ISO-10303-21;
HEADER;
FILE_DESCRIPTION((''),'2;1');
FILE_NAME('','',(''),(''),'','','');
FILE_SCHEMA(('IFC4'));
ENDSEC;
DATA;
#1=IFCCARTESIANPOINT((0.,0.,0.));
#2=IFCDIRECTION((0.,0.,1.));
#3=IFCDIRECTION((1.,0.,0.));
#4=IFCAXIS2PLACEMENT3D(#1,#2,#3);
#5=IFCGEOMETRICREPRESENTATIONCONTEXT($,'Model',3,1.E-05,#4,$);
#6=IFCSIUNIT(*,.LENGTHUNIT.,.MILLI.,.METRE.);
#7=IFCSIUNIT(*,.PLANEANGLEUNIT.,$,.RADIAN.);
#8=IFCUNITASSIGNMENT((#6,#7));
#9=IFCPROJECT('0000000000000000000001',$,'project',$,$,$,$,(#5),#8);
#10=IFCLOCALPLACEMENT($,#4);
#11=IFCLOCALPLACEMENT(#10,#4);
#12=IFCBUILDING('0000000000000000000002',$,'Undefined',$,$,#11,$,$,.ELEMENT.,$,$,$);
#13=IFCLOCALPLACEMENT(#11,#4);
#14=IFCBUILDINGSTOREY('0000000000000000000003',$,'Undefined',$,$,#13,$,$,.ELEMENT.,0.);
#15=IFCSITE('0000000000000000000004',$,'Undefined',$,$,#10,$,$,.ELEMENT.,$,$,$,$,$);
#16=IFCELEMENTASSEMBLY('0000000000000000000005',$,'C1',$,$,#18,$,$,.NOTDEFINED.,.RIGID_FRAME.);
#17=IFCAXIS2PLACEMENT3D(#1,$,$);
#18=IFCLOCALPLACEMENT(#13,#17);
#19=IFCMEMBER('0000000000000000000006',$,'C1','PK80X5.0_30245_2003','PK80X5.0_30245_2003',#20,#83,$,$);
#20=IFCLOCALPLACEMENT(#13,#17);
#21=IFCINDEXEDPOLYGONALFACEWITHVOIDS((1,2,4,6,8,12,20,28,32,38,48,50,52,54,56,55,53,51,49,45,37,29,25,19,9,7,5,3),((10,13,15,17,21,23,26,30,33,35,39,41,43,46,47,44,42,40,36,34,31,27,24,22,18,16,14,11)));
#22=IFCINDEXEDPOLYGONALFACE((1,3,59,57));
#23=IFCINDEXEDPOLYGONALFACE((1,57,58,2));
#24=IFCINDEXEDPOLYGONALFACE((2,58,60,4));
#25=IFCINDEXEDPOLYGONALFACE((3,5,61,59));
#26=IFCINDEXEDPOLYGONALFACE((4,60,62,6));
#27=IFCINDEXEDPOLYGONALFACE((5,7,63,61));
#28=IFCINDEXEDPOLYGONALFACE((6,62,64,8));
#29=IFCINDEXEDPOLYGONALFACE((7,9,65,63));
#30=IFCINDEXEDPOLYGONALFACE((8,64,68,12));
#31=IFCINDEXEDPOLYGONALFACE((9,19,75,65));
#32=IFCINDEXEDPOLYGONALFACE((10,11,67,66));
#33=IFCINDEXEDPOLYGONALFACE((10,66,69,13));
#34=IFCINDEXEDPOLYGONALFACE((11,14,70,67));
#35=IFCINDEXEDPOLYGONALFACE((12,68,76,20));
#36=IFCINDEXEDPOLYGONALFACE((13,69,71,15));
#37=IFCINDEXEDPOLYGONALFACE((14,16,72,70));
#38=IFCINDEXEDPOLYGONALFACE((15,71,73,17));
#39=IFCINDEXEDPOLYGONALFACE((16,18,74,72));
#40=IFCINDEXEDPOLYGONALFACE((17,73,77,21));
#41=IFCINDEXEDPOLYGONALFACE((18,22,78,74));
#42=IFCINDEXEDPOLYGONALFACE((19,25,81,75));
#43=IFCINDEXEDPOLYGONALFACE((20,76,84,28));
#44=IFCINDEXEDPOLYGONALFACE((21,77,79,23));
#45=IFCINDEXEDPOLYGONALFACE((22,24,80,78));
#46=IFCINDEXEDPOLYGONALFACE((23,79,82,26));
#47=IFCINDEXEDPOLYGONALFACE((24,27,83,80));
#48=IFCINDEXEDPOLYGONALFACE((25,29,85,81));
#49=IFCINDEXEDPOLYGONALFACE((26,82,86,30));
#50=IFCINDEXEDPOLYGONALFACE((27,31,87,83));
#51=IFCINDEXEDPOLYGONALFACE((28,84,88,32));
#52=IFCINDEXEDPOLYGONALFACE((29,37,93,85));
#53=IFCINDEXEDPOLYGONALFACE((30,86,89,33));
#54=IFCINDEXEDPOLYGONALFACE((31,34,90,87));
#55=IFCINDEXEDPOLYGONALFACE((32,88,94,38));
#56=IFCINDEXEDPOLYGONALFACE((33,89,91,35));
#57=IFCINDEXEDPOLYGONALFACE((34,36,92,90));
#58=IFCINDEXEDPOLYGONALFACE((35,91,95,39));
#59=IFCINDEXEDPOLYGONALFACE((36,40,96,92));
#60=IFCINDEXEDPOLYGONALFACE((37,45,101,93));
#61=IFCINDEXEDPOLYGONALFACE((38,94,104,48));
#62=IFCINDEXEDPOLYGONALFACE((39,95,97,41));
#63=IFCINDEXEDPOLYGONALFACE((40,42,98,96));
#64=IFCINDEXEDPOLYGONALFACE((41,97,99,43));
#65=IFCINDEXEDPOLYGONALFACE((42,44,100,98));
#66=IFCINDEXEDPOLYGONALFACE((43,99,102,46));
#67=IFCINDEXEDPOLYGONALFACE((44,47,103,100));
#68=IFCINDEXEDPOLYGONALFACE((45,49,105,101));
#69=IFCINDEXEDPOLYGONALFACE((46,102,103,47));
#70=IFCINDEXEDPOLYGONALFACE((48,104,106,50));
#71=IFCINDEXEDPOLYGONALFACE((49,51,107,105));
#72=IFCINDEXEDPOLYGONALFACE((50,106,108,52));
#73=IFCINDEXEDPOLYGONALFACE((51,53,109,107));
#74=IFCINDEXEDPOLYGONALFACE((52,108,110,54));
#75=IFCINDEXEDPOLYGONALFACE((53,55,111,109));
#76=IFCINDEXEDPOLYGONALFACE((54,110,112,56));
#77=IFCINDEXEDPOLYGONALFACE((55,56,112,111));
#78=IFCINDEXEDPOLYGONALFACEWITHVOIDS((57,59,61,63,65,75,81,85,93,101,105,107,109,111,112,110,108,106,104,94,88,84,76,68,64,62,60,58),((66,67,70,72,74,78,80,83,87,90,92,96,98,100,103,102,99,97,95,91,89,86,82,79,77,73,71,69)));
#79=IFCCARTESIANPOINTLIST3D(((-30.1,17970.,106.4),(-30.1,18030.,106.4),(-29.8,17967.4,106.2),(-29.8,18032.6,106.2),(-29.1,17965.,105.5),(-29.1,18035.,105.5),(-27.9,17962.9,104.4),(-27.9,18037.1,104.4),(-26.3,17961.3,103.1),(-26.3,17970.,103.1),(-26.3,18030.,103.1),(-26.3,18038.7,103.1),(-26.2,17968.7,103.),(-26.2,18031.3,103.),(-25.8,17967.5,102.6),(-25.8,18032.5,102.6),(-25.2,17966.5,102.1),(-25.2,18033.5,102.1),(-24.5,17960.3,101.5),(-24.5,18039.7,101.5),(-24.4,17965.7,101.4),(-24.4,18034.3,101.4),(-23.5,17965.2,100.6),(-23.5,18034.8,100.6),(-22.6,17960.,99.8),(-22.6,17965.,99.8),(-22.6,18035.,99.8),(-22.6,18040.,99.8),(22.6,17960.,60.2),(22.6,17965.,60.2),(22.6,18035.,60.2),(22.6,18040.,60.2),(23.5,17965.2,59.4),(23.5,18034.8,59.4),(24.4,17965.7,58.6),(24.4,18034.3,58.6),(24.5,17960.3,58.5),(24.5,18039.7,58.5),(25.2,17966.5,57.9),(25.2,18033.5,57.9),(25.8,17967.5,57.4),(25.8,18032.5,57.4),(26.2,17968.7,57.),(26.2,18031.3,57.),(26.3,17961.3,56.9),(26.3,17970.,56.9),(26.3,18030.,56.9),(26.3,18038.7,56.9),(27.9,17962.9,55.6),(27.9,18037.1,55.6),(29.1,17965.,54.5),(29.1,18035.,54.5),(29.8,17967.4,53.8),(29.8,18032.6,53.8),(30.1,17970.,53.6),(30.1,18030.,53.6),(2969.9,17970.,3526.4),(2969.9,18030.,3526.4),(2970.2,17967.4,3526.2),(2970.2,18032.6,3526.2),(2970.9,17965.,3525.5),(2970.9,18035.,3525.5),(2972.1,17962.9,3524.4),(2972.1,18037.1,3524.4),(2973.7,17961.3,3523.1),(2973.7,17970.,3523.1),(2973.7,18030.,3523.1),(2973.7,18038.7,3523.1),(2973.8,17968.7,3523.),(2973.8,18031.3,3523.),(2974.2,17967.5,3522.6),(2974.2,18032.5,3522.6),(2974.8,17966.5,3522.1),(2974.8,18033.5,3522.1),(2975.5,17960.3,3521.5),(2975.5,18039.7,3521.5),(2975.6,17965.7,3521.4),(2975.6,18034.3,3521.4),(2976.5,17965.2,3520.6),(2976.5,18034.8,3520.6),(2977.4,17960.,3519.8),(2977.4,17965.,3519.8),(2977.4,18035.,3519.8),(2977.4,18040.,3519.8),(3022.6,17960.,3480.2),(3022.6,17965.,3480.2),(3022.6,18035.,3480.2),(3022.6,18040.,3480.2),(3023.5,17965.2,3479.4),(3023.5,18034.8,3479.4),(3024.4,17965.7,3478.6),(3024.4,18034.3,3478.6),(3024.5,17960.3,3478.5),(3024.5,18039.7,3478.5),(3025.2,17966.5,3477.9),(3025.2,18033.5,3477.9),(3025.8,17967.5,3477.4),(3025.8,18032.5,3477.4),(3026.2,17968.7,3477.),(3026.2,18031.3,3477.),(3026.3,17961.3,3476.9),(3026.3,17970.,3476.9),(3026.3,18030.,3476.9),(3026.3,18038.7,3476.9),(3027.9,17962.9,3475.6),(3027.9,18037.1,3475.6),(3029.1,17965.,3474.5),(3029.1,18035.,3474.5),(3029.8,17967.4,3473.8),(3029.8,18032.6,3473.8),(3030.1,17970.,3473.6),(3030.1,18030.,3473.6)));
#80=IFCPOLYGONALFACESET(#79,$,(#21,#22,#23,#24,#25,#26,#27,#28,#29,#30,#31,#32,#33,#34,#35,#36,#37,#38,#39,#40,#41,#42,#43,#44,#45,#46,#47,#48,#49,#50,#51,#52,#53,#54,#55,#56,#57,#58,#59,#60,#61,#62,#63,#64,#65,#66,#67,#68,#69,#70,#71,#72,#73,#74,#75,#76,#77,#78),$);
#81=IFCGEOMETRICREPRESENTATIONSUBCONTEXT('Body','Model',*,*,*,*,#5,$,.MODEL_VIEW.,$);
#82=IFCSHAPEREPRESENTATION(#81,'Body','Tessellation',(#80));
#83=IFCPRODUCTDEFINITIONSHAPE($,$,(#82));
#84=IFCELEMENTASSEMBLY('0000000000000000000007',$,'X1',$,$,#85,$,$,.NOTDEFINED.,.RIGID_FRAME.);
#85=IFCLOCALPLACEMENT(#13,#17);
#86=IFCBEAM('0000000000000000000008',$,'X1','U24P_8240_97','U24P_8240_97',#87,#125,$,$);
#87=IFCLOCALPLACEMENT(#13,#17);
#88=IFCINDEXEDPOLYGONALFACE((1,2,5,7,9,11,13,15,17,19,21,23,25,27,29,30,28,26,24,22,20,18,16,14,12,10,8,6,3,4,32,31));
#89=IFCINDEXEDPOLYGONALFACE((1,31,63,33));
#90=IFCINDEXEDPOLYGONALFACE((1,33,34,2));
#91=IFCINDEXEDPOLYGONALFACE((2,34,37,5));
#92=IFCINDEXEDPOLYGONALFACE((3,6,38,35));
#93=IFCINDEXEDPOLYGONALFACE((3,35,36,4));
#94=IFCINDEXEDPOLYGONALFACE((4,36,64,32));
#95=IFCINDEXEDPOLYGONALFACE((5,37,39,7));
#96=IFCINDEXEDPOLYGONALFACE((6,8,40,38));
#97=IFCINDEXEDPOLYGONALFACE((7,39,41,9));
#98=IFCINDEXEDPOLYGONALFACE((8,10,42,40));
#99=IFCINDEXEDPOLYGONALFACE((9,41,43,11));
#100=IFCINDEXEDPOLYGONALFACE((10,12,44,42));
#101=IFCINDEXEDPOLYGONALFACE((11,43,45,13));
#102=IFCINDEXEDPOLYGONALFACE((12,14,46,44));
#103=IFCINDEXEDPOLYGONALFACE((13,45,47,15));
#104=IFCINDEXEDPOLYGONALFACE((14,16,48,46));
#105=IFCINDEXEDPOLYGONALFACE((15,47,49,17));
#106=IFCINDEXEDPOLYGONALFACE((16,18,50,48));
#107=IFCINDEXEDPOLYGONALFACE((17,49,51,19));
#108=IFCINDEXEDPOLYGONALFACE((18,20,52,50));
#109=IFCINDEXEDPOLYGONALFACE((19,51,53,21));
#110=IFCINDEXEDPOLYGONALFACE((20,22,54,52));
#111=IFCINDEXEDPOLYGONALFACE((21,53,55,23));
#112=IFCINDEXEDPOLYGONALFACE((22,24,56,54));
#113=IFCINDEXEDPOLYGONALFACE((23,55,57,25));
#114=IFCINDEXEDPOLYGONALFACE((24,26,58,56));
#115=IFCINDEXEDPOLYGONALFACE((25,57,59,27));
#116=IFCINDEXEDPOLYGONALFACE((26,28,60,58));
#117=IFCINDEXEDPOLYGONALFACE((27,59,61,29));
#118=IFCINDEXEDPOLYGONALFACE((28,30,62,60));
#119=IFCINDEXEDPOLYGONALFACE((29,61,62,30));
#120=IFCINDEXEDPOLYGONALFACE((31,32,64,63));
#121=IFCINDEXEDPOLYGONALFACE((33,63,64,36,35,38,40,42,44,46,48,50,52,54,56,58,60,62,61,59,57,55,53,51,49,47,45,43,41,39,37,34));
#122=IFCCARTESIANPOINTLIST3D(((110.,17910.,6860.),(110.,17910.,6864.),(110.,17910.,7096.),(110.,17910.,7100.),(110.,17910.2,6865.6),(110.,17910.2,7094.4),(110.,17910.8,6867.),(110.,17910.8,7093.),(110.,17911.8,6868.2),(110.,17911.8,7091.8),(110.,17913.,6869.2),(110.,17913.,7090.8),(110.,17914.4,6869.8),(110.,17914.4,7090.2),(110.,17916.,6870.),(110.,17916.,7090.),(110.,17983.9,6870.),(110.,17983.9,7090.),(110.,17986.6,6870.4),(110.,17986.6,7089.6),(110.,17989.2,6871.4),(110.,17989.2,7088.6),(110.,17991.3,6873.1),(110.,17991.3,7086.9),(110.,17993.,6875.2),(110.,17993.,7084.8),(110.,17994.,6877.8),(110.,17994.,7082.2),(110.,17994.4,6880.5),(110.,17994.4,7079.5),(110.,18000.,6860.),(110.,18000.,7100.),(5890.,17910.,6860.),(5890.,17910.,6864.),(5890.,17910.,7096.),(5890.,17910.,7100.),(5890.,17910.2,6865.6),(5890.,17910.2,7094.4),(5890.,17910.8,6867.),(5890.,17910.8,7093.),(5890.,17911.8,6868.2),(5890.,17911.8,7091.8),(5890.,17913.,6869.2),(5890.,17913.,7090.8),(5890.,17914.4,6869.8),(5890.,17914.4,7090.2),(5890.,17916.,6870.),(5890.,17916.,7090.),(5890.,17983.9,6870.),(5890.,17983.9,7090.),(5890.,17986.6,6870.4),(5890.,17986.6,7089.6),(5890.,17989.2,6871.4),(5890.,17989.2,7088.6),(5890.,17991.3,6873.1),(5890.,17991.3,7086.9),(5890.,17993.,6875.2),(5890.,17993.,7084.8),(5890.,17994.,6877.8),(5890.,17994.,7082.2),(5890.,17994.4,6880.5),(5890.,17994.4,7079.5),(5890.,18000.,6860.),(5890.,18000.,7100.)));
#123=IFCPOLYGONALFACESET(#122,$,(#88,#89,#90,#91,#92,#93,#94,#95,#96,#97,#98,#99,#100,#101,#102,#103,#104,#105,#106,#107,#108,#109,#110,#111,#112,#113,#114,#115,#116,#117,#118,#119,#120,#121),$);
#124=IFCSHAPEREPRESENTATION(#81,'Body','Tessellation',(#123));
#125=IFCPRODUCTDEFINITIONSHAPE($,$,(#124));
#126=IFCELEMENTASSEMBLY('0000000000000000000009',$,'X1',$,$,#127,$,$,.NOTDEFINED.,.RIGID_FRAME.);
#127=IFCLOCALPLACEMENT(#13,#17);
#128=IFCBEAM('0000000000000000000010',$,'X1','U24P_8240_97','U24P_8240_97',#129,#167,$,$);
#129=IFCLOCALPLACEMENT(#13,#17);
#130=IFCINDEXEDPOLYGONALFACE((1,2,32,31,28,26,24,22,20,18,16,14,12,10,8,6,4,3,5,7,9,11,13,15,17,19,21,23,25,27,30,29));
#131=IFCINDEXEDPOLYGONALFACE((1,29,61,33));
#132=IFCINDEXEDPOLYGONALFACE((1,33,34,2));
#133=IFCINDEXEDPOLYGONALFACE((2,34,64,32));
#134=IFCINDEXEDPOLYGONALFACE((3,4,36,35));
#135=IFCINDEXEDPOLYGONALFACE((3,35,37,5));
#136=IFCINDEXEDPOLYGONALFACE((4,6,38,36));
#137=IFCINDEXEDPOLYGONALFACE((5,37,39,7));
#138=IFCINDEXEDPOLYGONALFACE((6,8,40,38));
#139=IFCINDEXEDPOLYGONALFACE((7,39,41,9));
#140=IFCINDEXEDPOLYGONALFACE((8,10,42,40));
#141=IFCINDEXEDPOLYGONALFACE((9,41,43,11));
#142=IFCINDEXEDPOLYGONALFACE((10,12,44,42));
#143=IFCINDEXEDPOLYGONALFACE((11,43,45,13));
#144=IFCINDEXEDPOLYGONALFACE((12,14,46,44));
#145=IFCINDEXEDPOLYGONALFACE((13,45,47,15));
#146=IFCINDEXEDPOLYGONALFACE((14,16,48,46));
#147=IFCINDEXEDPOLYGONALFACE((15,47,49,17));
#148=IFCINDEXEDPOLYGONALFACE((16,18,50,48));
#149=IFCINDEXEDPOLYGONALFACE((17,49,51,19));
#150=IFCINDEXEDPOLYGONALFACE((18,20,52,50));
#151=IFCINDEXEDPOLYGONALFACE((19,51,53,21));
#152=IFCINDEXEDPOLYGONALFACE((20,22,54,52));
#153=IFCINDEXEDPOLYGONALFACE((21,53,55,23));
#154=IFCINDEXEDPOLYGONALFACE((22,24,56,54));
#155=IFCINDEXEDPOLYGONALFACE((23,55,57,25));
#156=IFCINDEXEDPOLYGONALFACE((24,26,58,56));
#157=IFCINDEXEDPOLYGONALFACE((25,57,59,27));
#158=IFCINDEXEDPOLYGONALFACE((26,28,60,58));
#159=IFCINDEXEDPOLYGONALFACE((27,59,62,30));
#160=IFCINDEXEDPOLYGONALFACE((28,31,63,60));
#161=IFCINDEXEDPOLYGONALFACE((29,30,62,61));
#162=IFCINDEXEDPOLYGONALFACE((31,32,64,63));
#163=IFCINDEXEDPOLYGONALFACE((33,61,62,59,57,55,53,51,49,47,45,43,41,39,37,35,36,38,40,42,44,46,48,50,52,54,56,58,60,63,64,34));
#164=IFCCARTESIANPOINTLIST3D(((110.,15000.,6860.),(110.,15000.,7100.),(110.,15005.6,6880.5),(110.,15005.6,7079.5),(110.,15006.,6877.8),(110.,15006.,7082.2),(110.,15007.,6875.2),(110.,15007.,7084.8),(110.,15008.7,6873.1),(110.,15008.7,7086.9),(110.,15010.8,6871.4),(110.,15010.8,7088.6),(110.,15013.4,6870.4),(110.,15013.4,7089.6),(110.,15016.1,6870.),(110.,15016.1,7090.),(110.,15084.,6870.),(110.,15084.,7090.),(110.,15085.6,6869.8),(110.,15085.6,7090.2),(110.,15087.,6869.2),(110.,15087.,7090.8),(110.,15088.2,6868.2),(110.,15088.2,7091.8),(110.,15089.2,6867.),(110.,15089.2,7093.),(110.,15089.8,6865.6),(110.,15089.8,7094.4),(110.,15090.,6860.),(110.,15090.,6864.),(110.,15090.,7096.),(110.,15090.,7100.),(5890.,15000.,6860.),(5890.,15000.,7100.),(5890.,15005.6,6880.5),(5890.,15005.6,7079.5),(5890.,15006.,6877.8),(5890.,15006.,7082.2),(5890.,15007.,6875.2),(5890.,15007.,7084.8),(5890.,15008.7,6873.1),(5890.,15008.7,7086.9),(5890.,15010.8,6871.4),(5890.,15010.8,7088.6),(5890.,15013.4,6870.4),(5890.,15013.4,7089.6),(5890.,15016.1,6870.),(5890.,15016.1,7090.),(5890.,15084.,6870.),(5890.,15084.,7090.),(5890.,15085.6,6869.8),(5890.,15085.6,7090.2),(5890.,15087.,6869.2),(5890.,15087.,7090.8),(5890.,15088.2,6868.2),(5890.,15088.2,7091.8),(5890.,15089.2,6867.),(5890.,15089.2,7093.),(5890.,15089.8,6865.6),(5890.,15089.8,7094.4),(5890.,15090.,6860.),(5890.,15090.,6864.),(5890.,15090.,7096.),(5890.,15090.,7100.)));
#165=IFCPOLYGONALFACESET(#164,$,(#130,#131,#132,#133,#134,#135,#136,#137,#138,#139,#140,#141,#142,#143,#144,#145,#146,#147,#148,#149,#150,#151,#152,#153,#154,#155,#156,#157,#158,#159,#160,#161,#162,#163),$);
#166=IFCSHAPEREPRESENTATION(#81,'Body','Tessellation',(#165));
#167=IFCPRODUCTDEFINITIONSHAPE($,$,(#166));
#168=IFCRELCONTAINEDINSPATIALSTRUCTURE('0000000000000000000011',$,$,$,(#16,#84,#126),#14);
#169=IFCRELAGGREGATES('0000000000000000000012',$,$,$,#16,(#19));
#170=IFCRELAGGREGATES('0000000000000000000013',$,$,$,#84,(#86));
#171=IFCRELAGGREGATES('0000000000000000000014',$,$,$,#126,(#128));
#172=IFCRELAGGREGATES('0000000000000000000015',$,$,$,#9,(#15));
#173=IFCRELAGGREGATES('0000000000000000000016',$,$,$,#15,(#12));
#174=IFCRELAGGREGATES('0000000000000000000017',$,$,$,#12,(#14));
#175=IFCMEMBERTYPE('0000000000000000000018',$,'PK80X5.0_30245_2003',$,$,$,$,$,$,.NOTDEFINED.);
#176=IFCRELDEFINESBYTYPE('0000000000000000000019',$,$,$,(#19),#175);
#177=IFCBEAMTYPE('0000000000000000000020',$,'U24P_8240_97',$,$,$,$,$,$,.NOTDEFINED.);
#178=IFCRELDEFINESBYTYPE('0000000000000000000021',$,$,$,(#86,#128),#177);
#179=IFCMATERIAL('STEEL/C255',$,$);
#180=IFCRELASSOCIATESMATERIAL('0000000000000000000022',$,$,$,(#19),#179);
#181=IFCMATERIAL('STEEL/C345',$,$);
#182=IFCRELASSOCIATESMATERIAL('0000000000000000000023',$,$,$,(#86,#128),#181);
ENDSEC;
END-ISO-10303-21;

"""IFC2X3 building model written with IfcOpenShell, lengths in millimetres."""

from ifc_helpers import new_model, si_unit, frame, origin_with_axes, origin_2d_with_axis, place, context, subcontext, project, spatial, hollow_rectangle, u_section, extrude, material, type_object, element, aggregate, save


model = new_model("IFC2X3")

# Units and contexts
model_context = context("Model", 3, precision=1e-05, world=origin_with_axes())
body_context = subcontext(model_context, "Body", "Model", "MODEL_VIEW")
ifc_project = project(units=[si_unit("LENGTHUNIT", "METRE", prefix="MILLI"), si_unit("PLANEANGLEUNIT", "RADIAN")], contexts=[model_context])

# Site, building, storey
site_placement = place(None, origin_with_axes())
site = spatial("IfcSite", under=ifc_project, at=site_placement, Name="Undefined", CompositionType="ELEMENT")
building_placement = place(site_placement, origin_with_axes())
building = spatial("IfcBuilding", under=site, at=building_placement, Name="Undefined", CompositionType="ELEMENT")
storey_placement = place(building_placement, origin_with_axes())
storey = spatial("IfcBuildingStorey", under=building, at=storey_placement, Name="Undefined", CompositionType="ELEMENT", Elevation=0.0)

# Shared definitions
ifc_material_1 = material(Name="STEEL/C345")

# Shared definitions
ifc_material_2 = material(Name="STEEL/C255")

# Element assembly, member
member_type = type_object("IfcMemberType", Name="PK80X5.0_30245_2003", PredefinedType="NOTDEFINED")
assembly_1_placement = place(storey_placement, origin_with_axes())
assembly_1 = element("IfcElementAssembly", 1, at=assembly_1_placement, inside=storey, Name="C1", AssemblyPlace="NOTDEFINED", PredefinedType="RIGID_FRAME")
member_1_placement = place(assembly_1_placement, frame((0.0, 18000.0, 80.0), z_axis=(0.751759, 0.0, -0.659438), x_axis=(0.659438, 0.0, 0.751759)))
member_1 = element("IfcMember", 2, at=member_1_placement, type_object=member_type, material=ifc_material_2, Name="C1", Description="PK80X5.0_30245_2003", ObjectType="PK80X5.0_30245_2003", context=body_context, shape_type="SweptSolid", body=[
    extrude(hollow_rectangle(XDim=80.0, YDim=80.0, WallThickness=5.0, InnerFilletRadius=5.0, OuterFilletRadius=10.0, at=origin_2d_with_axis()), frame((4549.3, 0.0, 0.0), z_axis=(-1.0, 0.0, 0.0), x_axis=(0.0, -1.0, 0.0)), (0.0, 0.0, 1.0), 4549.3),
])
aggregate(assembly_1, [member_1])

# Element assemblies, beams
assembly_2_placement = place(storey_placement, origin_with_axes())
assembly_2 = element("IfcElementAssembly", 3, at=assembly_2_placement, inside=storey, Name="X1", AssemblyPlace="NOTDEFINED", PredefinedType="RIGID_FRAME")
beam_type_1 = type_object("IfcBeamType", Name="U24P_8240_97", PredefinedType="NOTDEFINED")
beam_1_placement = place(assembly_2_placement, frame((110.0, 17955.0, 6980.0), z_axis=(0.0, 0.0, 1.0), x_axis=(1.0, 0.0, 0.0)))
beam_1 = element("IfcBeam", 4, at=beam_1_placement, type_object=beam_type_1, material=ifc_material_1, Name="X1", Description="U24P_8240_97", ObjectType="U24P_8240_97", context=body_context, shape_type="SweptSolid", body=[
    extrude(u_section(Depth=240.0, FlangeWidth=90.0, WebThickness=5.6, FlangeThickness=10.0, FilletRadius=10.5, EdgeRadius=6.0, at=origin_2d_with_axis()), frame((5780.0, 0.0, 0.0), z_axis=(-1.0, 0.0, 0.0), x_axis=(0.0, -1.0, 0.0)), (0.0, 0.0, 1.0), 5780.0),
])
aggregate(assembly_2, [beam_1])
assembly_3_placement = place(storey_placement, origin_with_axes())
assembly_3 = element("IfcElementAssembly", 5, at=assembly_3_placement, inside=storey, Name="X1", AssemblyPlace="NOTDEFINED", PredefinedType="RIGID_FRAME")
beam_2_placement = place(assembly_3_placement, frame((110.0, 15045.0, 6980.0), z_axis=(0.0, 0.0, -1.0), x_axis=(1.0, 0.0, 0.0)))
beam_2 = element("IfcBeam", 6, at=beam_2_placement, type_object=beam_type_1, material=ifc_material_1, Name="X1", Description="U24P_8240_97", ObjectType="U24P_8240_97", context=body_context, shape_type="SweptSolid", body=[
    extrude(u_section(Depth=240.0, FlangeWidth=90.0, WebThickness=5.6, FlangeThickness=10.0, FilletRadius=10.5, EdgeRadius=6.0, at=origin_2d_with_axis()), frame((5780.0, 0.0, 0.0), z_axis=(-1.0, 0.0, 0.0), x_axis=(0.0, -1.0, 0.0)), (0.0, 0.0, 1.0), 5780.0),
])
aggregate(assembly_3, [beam_2])

save(model, "model.ifc")
